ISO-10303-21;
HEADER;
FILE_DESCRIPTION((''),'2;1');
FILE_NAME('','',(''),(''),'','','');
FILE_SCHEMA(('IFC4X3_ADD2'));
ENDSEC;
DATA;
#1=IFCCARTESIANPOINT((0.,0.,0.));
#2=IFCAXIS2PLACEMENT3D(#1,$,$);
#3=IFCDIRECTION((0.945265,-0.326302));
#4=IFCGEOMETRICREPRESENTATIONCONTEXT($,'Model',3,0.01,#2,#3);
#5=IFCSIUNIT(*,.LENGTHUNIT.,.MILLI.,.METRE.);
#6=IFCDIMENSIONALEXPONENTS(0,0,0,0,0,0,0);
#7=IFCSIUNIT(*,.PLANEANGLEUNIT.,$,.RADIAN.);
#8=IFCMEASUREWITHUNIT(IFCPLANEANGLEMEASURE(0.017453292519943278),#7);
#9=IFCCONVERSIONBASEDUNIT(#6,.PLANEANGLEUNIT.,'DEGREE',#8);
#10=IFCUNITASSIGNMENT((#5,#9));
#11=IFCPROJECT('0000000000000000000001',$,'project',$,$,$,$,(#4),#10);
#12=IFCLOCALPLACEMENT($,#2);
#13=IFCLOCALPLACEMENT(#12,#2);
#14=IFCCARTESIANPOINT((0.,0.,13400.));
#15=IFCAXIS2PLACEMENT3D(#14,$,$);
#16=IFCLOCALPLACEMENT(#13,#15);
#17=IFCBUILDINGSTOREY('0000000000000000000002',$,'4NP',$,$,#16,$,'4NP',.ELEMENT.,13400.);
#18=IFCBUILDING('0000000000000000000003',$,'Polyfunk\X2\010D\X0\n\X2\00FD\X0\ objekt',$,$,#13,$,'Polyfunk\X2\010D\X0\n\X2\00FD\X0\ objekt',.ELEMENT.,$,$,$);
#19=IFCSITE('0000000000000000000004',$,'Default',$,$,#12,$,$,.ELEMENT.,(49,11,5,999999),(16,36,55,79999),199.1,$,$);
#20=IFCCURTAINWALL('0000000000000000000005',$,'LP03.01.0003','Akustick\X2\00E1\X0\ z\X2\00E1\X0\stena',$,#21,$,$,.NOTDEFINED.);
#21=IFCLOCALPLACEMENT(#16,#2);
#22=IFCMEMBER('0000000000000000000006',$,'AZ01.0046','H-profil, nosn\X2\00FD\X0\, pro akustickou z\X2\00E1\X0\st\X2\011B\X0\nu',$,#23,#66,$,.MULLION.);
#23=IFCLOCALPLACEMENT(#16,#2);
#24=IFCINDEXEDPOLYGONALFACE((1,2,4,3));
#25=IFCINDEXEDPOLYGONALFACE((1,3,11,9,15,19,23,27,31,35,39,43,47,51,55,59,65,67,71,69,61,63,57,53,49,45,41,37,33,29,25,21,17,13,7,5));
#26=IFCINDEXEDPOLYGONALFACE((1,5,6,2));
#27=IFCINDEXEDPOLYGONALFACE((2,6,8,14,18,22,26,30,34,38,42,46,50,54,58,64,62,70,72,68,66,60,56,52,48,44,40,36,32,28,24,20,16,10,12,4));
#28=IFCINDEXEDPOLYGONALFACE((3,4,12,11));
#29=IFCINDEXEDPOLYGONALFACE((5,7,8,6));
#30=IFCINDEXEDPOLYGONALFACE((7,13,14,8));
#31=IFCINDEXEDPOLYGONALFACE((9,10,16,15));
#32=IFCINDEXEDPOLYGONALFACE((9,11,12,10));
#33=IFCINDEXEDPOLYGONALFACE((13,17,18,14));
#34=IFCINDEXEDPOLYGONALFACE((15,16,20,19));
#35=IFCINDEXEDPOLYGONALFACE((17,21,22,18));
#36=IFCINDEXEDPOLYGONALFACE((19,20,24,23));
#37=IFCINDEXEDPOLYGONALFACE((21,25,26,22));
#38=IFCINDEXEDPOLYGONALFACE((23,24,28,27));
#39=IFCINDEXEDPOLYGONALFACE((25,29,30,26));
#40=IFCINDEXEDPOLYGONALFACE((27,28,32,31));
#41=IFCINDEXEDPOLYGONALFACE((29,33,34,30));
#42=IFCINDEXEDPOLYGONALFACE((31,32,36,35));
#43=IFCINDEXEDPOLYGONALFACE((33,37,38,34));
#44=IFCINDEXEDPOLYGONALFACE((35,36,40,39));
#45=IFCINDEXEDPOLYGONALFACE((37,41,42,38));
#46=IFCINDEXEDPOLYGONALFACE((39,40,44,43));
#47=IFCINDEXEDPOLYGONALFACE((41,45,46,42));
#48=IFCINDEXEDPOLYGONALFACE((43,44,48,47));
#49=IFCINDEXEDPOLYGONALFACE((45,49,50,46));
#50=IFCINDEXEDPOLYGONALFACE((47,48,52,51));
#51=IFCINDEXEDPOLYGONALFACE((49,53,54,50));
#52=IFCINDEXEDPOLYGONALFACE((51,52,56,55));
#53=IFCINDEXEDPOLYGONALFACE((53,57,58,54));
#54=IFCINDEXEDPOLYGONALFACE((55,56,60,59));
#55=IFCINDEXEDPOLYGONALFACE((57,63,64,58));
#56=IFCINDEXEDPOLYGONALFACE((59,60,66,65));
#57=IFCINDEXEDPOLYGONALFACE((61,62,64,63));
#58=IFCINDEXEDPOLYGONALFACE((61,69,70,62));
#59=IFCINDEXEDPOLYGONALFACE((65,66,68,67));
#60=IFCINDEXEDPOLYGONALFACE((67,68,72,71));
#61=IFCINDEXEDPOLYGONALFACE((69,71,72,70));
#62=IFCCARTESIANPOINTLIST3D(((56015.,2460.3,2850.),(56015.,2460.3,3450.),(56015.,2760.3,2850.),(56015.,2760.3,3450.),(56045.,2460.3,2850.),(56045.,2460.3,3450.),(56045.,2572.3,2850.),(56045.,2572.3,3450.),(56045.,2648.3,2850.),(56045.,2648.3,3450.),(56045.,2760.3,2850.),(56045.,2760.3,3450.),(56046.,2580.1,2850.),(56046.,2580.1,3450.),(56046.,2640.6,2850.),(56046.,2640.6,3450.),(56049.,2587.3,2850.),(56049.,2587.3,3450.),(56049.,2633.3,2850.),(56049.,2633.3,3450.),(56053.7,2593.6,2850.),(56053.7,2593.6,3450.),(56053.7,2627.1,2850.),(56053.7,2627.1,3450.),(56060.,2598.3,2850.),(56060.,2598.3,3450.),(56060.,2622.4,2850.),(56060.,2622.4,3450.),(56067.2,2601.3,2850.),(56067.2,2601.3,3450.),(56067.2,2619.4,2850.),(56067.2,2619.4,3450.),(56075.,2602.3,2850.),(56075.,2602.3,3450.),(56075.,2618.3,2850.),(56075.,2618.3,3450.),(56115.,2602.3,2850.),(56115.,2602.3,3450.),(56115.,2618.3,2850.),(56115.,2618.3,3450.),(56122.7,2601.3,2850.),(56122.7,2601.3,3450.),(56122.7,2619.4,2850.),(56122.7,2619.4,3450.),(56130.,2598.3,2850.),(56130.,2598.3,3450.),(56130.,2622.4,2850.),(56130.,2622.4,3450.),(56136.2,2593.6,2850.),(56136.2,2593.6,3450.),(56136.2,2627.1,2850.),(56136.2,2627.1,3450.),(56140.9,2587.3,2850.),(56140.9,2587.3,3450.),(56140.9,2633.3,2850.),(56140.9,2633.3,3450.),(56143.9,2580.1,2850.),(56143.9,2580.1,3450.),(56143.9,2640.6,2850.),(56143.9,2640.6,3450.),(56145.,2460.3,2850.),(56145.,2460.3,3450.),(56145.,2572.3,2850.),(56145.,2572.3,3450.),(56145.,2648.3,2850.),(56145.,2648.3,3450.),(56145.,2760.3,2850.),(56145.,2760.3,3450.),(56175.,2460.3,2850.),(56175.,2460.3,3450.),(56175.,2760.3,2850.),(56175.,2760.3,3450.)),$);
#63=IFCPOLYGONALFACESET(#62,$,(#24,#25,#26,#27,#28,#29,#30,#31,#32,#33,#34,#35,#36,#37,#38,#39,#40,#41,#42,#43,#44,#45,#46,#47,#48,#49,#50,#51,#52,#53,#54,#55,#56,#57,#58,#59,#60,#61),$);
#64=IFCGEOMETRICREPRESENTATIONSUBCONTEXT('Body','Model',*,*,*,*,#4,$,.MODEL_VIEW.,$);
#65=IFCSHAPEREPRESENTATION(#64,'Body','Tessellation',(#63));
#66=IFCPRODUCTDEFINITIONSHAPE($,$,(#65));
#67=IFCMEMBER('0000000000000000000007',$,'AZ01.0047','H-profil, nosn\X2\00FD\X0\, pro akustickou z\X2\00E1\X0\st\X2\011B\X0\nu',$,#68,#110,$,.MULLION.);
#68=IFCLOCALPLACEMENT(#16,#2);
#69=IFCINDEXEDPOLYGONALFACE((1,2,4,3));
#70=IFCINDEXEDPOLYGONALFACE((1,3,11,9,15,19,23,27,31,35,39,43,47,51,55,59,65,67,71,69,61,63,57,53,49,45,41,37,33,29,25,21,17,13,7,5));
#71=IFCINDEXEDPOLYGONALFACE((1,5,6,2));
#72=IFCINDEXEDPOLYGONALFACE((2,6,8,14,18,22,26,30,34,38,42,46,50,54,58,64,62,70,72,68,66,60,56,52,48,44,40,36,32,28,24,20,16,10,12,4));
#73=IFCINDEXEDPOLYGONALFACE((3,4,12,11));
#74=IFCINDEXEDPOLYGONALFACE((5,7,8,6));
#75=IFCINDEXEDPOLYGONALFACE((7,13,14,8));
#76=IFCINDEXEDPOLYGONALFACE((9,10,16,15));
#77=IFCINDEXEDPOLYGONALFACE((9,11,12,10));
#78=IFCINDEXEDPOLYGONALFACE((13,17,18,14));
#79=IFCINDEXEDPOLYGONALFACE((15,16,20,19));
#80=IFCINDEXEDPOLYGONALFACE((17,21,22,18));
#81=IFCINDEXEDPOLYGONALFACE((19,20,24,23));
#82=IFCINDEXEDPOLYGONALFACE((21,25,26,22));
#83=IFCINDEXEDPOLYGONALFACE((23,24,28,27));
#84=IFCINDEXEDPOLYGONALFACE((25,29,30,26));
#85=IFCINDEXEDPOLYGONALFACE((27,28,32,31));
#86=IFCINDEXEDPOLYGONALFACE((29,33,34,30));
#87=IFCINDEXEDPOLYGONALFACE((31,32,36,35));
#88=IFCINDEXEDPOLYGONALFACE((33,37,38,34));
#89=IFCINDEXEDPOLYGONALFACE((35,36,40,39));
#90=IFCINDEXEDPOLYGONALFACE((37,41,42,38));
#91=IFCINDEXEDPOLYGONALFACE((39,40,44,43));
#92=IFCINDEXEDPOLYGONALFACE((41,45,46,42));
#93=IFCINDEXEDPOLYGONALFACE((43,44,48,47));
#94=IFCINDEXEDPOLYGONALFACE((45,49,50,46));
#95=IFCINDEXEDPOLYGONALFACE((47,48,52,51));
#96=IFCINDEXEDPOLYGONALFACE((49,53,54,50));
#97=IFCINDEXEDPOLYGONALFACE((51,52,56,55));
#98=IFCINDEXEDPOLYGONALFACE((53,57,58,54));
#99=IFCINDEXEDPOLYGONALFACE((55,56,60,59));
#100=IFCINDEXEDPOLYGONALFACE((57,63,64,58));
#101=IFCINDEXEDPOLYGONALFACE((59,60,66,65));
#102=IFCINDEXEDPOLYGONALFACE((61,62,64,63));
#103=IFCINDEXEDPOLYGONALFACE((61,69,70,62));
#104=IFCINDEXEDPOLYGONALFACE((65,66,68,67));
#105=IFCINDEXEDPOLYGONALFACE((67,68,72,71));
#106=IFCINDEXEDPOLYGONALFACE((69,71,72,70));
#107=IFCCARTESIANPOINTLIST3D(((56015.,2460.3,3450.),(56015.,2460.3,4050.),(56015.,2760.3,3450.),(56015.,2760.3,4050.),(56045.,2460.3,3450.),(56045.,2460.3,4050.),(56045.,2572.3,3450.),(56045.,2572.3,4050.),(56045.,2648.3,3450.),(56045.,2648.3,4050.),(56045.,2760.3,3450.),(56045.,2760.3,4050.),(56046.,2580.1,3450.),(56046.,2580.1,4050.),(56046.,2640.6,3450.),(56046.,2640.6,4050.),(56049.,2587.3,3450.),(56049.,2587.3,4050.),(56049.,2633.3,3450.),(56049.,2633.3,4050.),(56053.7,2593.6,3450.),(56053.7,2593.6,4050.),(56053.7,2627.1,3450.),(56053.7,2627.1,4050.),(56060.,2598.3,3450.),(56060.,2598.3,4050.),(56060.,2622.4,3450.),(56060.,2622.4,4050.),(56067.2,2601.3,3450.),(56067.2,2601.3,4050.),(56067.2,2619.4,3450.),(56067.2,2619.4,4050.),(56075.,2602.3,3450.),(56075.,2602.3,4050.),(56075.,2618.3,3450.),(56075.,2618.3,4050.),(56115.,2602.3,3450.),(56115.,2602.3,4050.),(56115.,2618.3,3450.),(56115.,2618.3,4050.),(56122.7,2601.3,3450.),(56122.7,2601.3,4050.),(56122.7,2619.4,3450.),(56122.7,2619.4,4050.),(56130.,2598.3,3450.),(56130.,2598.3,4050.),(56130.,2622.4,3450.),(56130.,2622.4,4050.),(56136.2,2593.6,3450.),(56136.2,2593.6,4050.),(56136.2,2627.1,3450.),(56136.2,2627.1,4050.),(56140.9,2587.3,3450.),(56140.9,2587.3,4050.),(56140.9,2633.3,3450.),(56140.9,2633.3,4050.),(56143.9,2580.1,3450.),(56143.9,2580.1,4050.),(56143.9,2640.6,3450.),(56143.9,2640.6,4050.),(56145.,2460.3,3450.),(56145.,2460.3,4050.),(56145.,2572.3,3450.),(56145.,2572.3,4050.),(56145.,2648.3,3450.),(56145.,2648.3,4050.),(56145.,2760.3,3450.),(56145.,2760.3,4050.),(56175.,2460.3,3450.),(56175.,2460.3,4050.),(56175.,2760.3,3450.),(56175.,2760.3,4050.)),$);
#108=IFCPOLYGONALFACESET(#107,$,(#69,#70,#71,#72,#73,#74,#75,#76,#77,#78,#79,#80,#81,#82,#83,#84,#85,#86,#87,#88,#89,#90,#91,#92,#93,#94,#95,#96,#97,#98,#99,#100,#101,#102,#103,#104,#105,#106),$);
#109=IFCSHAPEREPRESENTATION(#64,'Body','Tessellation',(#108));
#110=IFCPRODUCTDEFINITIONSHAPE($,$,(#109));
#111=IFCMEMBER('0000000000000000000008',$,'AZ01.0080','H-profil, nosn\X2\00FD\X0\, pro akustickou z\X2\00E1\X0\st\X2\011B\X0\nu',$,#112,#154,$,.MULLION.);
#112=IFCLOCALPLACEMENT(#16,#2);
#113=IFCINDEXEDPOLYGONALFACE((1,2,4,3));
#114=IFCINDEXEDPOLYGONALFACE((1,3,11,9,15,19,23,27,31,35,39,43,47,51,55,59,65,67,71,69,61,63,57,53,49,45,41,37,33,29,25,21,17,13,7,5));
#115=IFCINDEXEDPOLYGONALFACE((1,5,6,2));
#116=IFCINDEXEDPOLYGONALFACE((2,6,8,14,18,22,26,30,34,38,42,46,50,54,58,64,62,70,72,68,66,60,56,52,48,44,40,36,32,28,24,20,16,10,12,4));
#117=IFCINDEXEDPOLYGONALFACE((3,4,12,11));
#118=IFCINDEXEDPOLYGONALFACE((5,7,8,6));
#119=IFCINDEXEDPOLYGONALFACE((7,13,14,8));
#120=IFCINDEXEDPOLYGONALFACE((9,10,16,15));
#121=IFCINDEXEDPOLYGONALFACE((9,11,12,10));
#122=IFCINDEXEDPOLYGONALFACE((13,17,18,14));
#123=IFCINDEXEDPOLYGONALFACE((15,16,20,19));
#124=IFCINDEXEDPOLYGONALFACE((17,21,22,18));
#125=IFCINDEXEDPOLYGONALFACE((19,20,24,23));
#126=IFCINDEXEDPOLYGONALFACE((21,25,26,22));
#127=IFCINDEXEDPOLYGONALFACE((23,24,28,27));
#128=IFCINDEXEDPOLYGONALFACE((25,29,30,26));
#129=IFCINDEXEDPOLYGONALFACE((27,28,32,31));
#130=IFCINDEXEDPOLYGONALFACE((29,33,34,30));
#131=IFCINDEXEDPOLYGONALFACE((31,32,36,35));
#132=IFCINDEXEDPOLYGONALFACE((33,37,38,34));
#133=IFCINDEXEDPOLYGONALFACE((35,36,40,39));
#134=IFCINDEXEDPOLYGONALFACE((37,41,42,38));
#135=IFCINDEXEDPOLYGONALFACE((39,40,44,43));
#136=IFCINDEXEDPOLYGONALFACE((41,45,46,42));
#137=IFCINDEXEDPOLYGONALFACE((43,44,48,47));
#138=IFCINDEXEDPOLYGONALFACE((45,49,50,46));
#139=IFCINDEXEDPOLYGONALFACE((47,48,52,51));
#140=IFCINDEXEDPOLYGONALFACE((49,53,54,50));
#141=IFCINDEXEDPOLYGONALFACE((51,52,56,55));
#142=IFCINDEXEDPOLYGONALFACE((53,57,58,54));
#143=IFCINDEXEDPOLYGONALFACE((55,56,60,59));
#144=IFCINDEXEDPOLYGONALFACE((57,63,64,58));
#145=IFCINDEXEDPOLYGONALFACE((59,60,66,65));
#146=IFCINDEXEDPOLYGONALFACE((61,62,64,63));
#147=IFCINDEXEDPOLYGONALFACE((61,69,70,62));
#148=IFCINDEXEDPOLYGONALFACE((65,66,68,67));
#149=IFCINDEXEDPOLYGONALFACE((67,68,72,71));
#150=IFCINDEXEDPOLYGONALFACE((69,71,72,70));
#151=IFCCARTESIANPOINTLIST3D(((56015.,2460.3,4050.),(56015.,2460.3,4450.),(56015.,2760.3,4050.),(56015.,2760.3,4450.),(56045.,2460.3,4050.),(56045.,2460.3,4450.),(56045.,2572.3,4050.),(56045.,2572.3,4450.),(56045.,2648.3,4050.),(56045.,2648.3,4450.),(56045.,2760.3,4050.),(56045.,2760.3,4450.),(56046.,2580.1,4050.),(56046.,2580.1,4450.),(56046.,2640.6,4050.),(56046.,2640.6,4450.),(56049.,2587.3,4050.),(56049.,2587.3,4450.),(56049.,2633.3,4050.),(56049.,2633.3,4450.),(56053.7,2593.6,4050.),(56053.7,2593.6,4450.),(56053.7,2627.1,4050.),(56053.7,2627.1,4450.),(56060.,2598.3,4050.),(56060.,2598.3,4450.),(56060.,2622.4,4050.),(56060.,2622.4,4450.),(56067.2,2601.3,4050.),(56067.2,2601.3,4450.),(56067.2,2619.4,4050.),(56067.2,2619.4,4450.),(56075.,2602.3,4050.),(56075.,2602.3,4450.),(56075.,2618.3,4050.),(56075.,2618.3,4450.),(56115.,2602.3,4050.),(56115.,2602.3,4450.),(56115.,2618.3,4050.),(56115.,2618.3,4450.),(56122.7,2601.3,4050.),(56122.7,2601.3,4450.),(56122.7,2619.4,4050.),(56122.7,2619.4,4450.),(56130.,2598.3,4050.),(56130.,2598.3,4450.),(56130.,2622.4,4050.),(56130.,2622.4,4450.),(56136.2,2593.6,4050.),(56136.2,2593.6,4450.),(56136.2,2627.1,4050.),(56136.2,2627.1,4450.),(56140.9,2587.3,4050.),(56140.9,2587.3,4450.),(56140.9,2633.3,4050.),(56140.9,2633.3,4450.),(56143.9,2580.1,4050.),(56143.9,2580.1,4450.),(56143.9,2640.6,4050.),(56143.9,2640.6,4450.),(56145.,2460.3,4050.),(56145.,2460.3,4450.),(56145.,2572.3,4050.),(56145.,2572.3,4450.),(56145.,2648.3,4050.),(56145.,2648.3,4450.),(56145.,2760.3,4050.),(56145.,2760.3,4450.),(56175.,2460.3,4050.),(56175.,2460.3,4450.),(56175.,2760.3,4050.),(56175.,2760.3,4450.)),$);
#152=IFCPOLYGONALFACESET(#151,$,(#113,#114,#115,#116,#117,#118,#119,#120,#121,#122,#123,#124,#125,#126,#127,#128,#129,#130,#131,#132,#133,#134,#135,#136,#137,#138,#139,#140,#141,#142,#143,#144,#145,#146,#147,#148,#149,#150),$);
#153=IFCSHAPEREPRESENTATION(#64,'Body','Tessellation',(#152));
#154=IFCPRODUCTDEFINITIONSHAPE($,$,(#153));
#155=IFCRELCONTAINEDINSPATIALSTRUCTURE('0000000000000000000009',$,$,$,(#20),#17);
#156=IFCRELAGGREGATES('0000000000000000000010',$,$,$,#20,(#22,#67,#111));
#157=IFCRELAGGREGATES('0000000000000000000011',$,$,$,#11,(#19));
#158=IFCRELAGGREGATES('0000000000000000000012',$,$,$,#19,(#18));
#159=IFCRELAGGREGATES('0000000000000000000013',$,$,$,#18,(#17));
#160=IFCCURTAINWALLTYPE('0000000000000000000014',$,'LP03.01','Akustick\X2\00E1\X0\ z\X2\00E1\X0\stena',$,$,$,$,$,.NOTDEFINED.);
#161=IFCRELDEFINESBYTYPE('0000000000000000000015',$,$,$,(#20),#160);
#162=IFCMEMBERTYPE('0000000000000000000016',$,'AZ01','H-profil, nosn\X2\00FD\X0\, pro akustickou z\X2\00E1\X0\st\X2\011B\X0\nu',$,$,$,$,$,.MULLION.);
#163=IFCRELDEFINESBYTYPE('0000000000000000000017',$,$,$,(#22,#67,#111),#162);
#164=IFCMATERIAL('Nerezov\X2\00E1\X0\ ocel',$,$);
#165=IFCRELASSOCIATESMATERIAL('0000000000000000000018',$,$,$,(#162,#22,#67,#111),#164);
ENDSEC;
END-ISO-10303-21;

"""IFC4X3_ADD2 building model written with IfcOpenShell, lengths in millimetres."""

from ifc_helpers import new_model, entity, si_unit, converted_unit, direction, frame, frame_2d, origin, place, context, subcontext, project, spatial, polyline, circle_curve, parameter, trimmed, segment, composite_curve, outline, extrude, source, transform, mapped, material, material_profile, profile_set, profile_usage, type_object, element, aggregate, save


model = new_model("IFC4X3_ADD2")

# Units and contexts
model_context = context("Model", 3, precision=0.01, world=origin(), true_north=direction((0.945265, -0.326302)))
body_context = subcontext(model_context, "Body", "Model", "MODEL_VIEW")
ifc_project = project(units=[si_unit("LENGTHUNIT", "METRE", prefix="MILLI"), converted_unit("PLANEANGLEUNIT", "DEGREE", entity("IfcPlaneAngleMeasure", 0.017453292519943278), si_unit("PLANEANGLEUNIT", "RADIAN"), dimensions=[0, 0, 0, 0, 0, 0, 0])], contexts=[model_context])

# Site, building, storey
site_placement = place(None, origin())
site = spatial("IfcSite", under=ifc_project, at=site_placement, Name="Default", CompositionType="ELEMENT", RefLatitude=(49, 11, 5, 999999), RefLongitude=(16, 36, 55, 79999), RefElevation=199.1)
building_placement = place(site_placement, origin())
building = spatial("IfcBuilding", under=site, at=building_placement, Name="Polyfunkčný objekt", LongName="Polyfunkčný objekt", CompositionType="ELEMENT")
storey_placement = place(building_placement, frame((0.0, 0.0, 13400.0)))
storey = spatial("IfcBuildingStorey", under=building, at=storey_placement, Name="4NP", LongName="4NP", CompositionType="ELEMENT", Elevation=13400.0)

# Shared definitions
curtain_wall_type = type_object("IfcCurtainWallType", Name="LP03.01", Description="Akustická zástena", PredefinedType="NOTDEFINED")
ifc_material_1 = material(Name="Nerezová ocel")
ifc_material_profile = material_profile(ifc_material_1, outline(composite_curve([segment(polyline([(50.0, -150.0), (80.0, -150.0)]), True, "CONTINUOUS"), segment(polyline([(80.0, -150.0), (80.0, 150.0)]), True, "CONTINUOUS"), segment(polyline([(80.0, 150.0), (50.0, 150.0)]), True, "CONTINUOUS"), segment(polyline([(50.0, 150.0), (50.0, 38.0)]), True, "CONTINUOUS"), segment(trimmed(circle_curve(frame_2d((20.0, 38.0), x_axis=(0.0, 1.0)), 30.0), [parameter(180.0)], [parameter(270.0)], True, "PARAMETER"), False, "CONTINUOUS"), segment(polyline([(20.0, 8.0), (-20.0, 8.0)]), True, "CONTINUOUS"), segment(trimmed(circle_curve(frame_2d((-20.0, 38.0), x_axis=(0.0, 1.0)), 30.0), [parameter(90.0)], [parameter(180.0)], True, "PARAMETER"), False, "CONTINUOUS"), segment(polyline([(-50.0, 38.0), (-50.0, 150.0)]), True, "CONTINUOUS"), segment(polyline([(-50.0, 150.0), (-80.0, 150.0)]), True, "CONTINUOUS"), segment(polyline([(-80.0, 150.0), (-80.0, -150.0)]), True, "CONTINUOUS"), segment(polyline([(-80.0, -150.0), (-50.0, -150.0)]), True, "CONTINUOUS"), segment(polyline([(-50.0, -150.0), (-50.0, -38.0)]), True, "CONTINUOUS"), segment(trimmed(circle_curve(frame_2d((-20.0, -38.0), x_axis=(0.0, 1.0)), 30.0), [parameter(0.0)], [parameter(90.0)], True, "PARAMETER"), False, "CONTINUOUS"), segment(polyline([(-20.0, -8.0), (20.0, -8.0)]), True, "CONTINUOUS"), segment(trimmed(circle_curve(frame_2d((20.0, -38.0), x_axis=(0.0, 1.0)), 30.0), [parameter(270.0)], [parameter(0.0)], True, "PARAMETER"), False, "CONTINUOUS"), segment(polyline([(50.0, -38.0), (50.0, -150.0)]), True, "CONTINUOUS")], self_intersect=False)), Name="Profil zástena")
ifc_profile_set = profile_set([ifc_material_profile], Name="Profil zástena")
ifc_profile_usage = profile_usage(ifc_profile_set)
member_type = type_object("IfcMemberType", Name="AZ01", Description="H-profil, nosný, pro akustickou zástěnu", PredefinedType="MULLION", material=ifc_profile_set)

# Curtain wall, members
curtain_wall_1_placement = place(storey_placement, frame((0.0, 0.0, -13400.0)))
curtain_wall_1 = element("IfcCurtainWall", 1, at=curtain_wall_1_placement, inside=storey, type_object=curtain_wall_type, Name="LP03.01.0003", Description="Akustická zástena", PredefinedType="NOTDEFINED")
shared_shape_1 = source(origin(), body_context, "Body", "SweptSolid", [
    extrude(outline(composite_curve([segment(polyline([(-150.0, -50.0), (-150.0, -80.0)]), True, "CONTINUOUS"), segment(polyline([(-150.0, -80.0), (150.0, -80.0)]), True, "CONTINUOUS"), segment(polyline([(150.0, -80.0), (150.0, -50.0)]), True, "CONTINUOUS"), segment(polyline([(150.0, -50.0), (38.0, -50.0)]), True, "CONTINUOUS"), segment(trimmed(circle_curve(frame_2d((38.0, -20.0), x_axis=(1.0, 0.0)), 30.0), [parameter(180.0)], [parameter(270.0)], True, "PARAMETER"), False, "CONTINUOUS"), segment(polyline([(8.0, -20.0), (8.0, 20.0)]), True, "CONTINUOUS"), segment(trimmed(circle_curve(frame_2d((38.0, 20.0), x_axis=(1.0, 0.0)), 30.0), [parameter(90.0)], [parameter(180.0)], True, "PARAMETER"), False, "CONTINUOUS"), segment(polyline([(38.0, 50.0), (150.0, 50.0)]), True, "CONTINUOUS"), segment(polyline([(150.0, 50.0), (150.0, 80.0)]), True, "CONTINUOUS"), segment(polyline([(150.0, 80.0), (-150.0, 80.0)]), True, "CONTINUOUS"), segment(polyline([(-150.0, 80.0), (-150.0, 50.0)]), True, "CONTINUOUS"), segment(polyline([(-150.0, 50.0), (-38.0, 50.0)]), True, "CONTINUOUS"), segment(trimmed(circle_curve(frame_2d((-38.0, 20.0), x_axis=(1.0, 0.0)), 30.0), [parameter(0.0)], [parameter(90.0)], True, "PARAMETER"), False, "CONTINUOUS"), segment(polyline([(-8.0, 20.0), (-8.0, -20.0)]), True, "CONTINUOUS"), segment(trimmed(circle_curve(frame_2d((-38.0, -20.0), x_axis=(1.0, 0.0)), 30.0), [parameter(270.0)], [parameter(0.0)], True, "PARAMETER"), False, "CONTINUOUS"), segment(polyline([(-38.0, -50.0), (-150.0, -50.0)]), True, "CONTINUOUS")], self_intersect=False)), frame((0.0, 0.0, -600.0), z_axis=(0.0, 0.0, -1.0), x_axis=(1.0, 0.0, 0.0)), (0.0, 0.0, -1.0), 600.0),
])
member_1_placement = place(curtain_wall_1_placement, frame((56095.0, 2610.3, 16250.0), z_axis=(0.0, 0.0, -1.0), x_axis=(0.0, 1.0, 0.0)))
member_1 = element("IfcMember", 2, at=member_1_placement, type_object=member_type, material=ifc_profile_usage, Name="AZ01.0046", Description="H-profil, nosný, pro akustickou zástěnu", PredefinedType="MULLION", context=body_context, shape_type="MappedRepresentation", body=[
    mapped(shared_shape_1, transform((0.0, 0.0, 0.0), scale=1.0)),
])
member_2_placement = place(curtain_wall_1_placement, frame((56095.0, 2610.3, 16850.0), z_axis=(0.0, 0.0, -1.0), x_axis=(0.0, 1.0, 0.0)))
member_2 = element("IfcMember", 3, at=member_2_placement, type_object=member_type, material=ifc_profile_usage, Name="AZ01.0047", Description="H-profil, nosný, pro akustickou zástěnu", PredefinedType="MULLION", context=body_context, shape_type="MappedRepresentation", body=[
    mapped(shared_shape_1, transform((0.0, 0.0, 0.0), scale=1.0)),
])
shared_shape_2 = source(origin(), body_context, "Body", "SweptSolid", [
    extrude(outline(composite_curve([segment(polyline([(-150.0, -50.0), (-150.0, -80.0)]), True, "CONTINUOUS"), segment(polyline([(-150.0, -80.0), (150.0, -80.0)]), True, "CONTINUOUS"), segment(polyline([(150.0, -80.0), (150.0, -50.0)]), True, "CONTINUOUS"), segment(polyline([(150.0, -50.0), (38.0, -50.0)]), True, "CONTINUOUS"), segment(trimmed(circle_curve(frame_2d((38.0, -20.0), x_axis=(1.0, 0.0)), 30.0), [parameter(180.0)], [parameter(270.0)], True, "PARAMETER"), False, "CONTINUOUS"), segment(polyline([(8.0, -20.0), (8.0, 20.0)]), True, "CONTINUOUS"), segment(trimmed(circle_curve(frame_2d((38.0, 20.0), x_axis=(1.0, 0.0)), 30.0), [parameter(90.0)], [parameter(180.0)], True, "PARAMETER"), False, "CONTINUOUS"), segment(polyline([(38.0, 50.0), (150.0, 50.0)]), True, "CONTINUOUS"), segment(polyline([(150.0, 50.0), (150.0, 80.0)]), True, "CONTINUOUS"), segment(polyline([(150.0, 80.0), (-150.0, 80.0)]), True, "CONTINUOUS"), segment(polyline([(-150.0, 80.0), (-150.0, 50.0)]), True, "CONTINUOUS"), segment(polyline([(-150.0, 50.0), (-38.0, 50.0)]), True, "CONTINUOUS"), segment(trimmed(circle_curve(frame_2d((-38.0, 20.0), x_axis=(1.0, 0.0)), 30.0), [parameter(0.0)], [parameter(90.0)], True, "PARAMETER"), False, "CONTINUOUS"), segment(polyline([(-8.0, 20.0), (-8.0, -20.0)]), True, "CONTINUOUS"), segment(trimmed(circle_curve(frame_2d((-38.0, -20.0), x_axis=(1.0, 0.0)), 30.0), [parameter(270.0)], [parameter(360.0)], True, "PARAMETER"), False, "CONTINUOUS"), segment(polyline([(-38.0, -50.0), (-150.0, -50.0)]), True, "CONTINUOUS")], self_intersect=False)), frame((0.0, 0.0, -400.0), z_axis=(0.0, 0.0, -1.0), x_axis=(1.0, 0.0, 0.0)), (0.0, 0.0, -1.0), 400.0),
])
member_3_placement = place(curtain_wall_1_placement, frame((56095.0, 2610.3, 17450.0), z_axis=(0.0, 0.0, -1.0), x_axis=(0.0, 1.0, 0.0)))
member_3 = element("IfcMember", 4, at=member_3_placement, type_object=member_type, material=ifc_profile_usage, Name="AZ01.0080", Description="H-profil, nosný, pro akustickou zástěnu", PredefinedType="MULLION", context=body_context, shape_type="MappedRepresentation", body=[
    mapped(shared_shape_2, transform((0.0, 0.0, 0.0), scale=1.0)),
])
aggregate(curtain_wall_1, [member_1, member_2, member_3])

save(model, "model.ifc")
